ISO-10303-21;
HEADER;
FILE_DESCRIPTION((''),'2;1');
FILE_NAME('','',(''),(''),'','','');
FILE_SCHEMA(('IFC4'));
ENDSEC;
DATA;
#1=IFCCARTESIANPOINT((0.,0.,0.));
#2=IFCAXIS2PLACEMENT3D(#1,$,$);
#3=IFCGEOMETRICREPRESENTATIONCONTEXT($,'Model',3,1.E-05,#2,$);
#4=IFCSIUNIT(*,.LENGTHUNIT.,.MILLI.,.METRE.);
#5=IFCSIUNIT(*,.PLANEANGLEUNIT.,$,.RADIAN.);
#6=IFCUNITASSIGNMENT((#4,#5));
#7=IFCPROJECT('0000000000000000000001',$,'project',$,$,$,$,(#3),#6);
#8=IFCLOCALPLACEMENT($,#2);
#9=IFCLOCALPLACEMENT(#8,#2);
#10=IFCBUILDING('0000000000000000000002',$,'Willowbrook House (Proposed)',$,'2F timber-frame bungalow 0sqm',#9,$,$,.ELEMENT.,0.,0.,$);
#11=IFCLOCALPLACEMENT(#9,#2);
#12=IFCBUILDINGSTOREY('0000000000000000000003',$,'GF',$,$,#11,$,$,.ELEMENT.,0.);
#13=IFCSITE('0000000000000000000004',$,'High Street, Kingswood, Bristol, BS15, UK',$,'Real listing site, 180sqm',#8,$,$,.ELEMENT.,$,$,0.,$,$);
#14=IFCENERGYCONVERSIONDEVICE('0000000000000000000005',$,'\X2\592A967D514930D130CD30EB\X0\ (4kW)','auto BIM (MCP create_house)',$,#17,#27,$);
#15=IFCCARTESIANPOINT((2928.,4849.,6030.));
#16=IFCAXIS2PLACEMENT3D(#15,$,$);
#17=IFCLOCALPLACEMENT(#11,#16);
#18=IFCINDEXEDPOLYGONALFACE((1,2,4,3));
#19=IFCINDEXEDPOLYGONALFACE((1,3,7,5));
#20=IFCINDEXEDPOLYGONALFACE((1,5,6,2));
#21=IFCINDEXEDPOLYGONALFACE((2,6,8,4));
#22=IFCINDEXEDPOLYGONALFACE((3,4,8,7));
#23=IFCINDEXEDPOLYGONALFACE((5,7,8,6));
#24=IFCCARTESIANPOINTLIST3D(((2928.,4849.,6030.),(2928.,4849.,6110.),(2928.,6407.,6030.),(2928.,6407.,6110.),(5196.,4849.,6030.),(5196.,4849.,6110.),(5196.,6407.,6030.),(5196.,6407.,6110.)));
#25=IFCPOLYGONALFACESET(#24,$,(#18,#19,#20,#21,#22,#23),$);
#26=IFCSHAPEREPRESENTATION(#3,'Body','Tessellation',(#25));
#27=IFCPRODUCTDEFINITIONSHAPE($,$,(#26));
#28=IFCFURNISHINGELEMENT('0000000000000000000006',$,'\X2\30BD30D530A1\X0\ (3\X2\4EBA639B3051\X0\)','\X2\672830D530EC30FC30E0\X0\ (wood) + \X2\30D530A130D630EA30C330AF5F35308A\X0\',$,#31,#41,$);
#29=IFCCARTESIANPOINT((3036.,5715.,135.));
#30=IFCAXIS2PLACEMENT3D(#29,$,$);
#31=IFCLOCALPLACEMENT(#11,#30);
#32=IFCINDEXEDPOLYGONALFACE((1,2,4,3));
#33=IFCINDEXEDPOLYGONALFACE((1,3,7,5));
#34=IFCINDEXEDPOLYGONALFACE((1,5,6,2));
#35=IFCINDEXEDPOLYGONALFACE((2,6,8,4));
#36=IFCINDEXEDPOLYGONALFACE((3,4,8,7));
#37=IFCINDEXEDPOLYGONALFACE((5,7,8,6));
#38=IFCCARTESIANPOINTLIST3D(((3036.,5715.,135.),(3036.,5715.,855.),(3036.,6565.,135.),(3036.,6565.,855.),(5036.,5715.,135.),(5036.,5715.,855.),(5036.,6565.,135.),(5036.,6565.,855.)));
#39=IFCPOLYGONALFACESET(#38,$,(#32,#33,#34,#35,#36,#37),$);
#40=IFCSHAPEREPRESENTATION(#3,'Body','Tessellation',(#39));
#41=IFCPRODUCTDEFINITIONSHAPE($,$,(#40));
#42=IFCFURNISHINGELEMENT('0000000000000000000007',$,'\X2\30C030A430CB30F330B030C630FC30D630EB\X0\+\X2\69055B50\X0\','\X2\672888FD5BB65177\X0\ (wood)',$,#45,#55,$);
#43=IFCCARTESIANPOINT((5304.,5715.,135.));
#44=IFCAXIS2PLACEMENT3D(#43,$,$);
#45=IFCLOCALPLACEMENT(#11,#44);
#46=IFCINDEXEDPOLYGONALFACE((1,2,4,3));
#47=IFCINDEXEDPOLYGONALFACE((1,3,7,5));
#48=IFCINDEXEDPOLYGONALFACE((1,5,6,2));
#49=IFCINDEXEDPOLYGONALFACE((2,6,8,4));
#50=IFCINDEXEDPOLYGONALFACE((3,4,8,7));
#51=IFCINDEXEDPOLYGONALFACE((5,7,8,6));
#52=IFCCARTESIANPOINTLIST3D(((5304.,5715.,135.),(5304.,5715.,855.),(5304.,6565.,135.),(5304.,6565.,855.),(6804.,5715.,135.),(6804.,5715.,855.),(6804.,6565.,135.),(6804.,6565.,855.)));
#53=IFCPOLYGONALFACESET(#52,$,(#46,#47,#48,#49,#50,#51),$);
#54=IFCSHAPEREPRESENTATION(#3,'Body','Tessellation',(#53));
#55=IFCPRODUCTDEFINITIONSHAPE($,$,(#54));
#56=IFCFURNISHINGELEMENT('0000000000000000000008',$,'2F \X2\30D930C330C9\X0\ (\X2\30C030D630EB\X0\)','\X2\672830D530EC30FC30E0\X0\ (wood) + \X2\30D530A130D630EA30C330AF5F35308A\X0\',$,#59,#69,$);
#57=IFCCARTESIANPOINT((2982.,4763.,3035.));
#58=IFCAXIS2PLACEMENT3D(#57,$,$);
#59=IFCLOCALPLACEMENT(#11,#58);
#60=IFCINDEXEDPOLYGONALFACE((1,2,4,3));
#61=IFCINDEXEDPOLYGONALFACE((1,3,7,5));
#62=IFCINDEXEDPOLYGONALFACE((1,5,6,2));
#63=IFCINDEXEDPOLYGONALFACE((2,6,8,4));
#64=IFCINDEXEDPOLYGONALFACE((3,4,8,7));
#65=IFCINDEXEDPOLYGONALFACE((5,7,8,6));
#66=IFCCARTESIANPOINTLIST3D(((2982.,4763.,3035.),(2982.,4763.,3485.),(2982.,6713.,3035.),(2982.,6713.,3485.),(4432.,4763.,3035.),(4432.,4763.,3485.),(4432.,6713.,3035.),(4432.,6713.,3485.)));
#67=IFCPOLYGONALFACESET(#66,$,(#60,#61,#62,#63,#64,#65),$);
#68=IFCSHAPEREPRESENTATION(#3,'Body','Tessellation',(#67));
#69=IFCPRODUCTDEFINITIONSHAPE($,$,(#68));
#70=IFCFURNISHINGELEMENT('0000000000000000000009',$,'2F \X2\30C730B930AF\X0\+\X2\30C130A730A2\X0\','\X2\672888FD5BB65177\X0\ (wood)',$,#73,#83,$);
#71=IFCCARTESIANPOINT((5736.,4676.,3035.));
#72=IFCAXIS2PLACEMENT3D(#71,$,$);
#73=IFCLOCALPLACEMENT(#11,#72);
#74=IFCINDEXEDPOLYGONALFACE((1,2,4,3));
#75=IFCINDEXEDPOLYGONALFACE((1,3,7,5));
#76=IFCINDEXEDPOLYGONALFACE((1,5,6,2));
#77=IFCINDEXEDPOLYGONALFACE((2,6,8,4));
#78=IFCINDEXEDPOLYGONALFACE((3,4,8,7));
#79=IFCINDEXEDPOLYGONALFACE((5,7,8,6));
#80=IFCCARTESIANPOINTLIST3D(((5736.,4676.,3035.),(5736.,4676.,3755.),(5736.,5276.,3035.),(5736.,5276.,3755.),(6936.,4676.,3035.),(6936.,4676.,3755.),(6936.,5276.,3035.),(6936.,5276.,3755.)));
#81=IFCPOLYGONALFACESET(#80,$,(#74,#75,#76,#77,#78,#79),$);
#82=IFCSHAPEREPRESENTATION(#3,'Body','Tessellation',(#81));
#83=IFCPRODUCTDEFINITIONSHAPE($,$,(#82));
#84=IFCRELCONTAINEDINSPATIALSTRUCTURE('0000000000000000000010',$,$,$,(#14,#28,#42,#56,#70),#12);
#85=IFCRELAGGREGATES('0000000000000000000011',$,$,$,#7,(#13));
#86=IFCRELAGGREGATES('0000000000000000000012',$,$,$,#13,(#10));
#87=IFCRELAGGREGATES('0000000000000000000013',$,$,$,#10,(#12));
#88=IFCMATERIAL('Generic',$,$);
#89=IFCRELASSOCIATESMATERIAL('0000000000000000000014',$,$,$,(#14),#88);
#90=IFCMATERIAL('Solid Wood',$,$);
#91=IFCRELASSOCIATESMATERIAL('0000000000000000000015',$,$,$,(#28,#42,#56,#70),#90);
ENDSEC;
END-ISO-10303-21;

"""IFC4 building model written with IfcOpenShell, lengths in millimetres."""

from ifc_helpers import new_model, si_unit, frame, frame_2d, origin, place, context, project, spatial, rectangle, extrude, material, element, save


model = new_model("IFC4")

# Units and contexts
model_context = context("Model", 3, precision=1e-05, world=origin())
ifc_project = project(units=[si_unit("LENGTHUNIT", "METRE", prefix="MILLI"), si_unit("PLANEANGLEUNIT", "RADIAN")], contexts=[model_context])

# Site, building, storey
site_placement = place(None, origin())
site = spatial("IfcSite", under=ifc_project, at=site_placement, Name="High Street, Kingswood, Bristol, BS15, UK", ObjectType="Real listing site, 180sqm", CompositionType="ELEMENT", RefElevation=0.0)
building_placement = place(site_placement, origin())
building = spatial("IfcBuilding", under=site, at=building_placement, Name="Willowbrook House (Proposed)", ObjectType="2F timber-frame bungalow 0sqm", CompositionType="ELEMENT", ElevationOfRefHeight=0.0, ElevationOfTerrain=0.0)
storey_placement = place(building_placement, origin())
storey = spatial("IfcBuildingStorey", under=building, at=storey_placement, Name="GF", CompositionType="ELEMENT", Elevation=0.0)

# Shared definitions
ifc_material_1 = material(Name="Solid Wood")

# Shared definitions
ifc_material_2 = material(Name="Generic")

# Energy conversion device
energy_conversion_device_placement = place(storey_placement, frame((2928.0, 4849.0, 6030.0)))
element("IfcEnergyConversionDevice", 1, at=energy_conversion_device_placement, inside=storey, material=ifc_material_2, Name="太陽光パネル (4kW)", Description="auto BIM (MCP create_house)", context=model_context, shape_type="SweptSolid", body=[
    extrude(rectangle(XDim=2268.0, YDim=1558.0, at=frame_2d((1134.0, 779.0))), frame((2928.0, 4849.0, 6030.0)), (0.0, 0.0, 1.0), 80.0),
])

# Furnishing elements
furnishing_1_placement = place(storey_placement, frame((3036.0, 5715.0, 135.0)))
element("IfcFurnishingElement", 2, at=furnishing_1_placement, inside=storey, material=ifc_material_1, Name="ソファ (3人掛け)", Description="木フレーム (wood) + ファブリック張り", context=model_context, shape_type="SweptSolid", body=[
    extrude(rectangle(XDim=2000.0, YDim=850.0, at=frame_2d((1000.0, 425.0))), frame((3036.0, 5715.0, 135.0)), (0.0, 0.0, 1.0), 720.0),
])
furnishing_2_placement = place(storey_placement, frame((5304.0, 5715.0, 135.0)))
element("IfcFurnishingElement", 3, at=furnishing_2_placement, inside=storey, material=ifc_material_1, Name="ダイニングテーブル+椅子", Description="木製家具 (wood)", context=model_context, shape_type="SweptSolid", body=[
    extrude(rectangle(XDim=1500.0, YDim=850.0, at=frame_2d((750.0, 425.0))), frame((5304.0, 5715.0, 135.0)), (0.0, 0.0, 1.0), 720.0),
])
furnishing_3_placement = place(storey_placement, frame((2982.0, 4763.0, 3035.0)))
element("IfcFurnishingElement", 4, at=furnishing_3_placement, inside=storey, material=ifc_material_1, Name="2F ベッド (ダブル)", Description="木フレーム (wood) + ファブリック張り", context=model_context, shape_type="SweptSolid", body=[
    extrude(rectangle(XDim=1450.0, YDim=1950.0, at=frame_2d((725.0, 975.0))), frame((2982.0, 4763.0, 3035.0)), (0.0, 0.0, 1.0), 450.0),
])
furnishing_4_placement = place(storey_placement, frame((5736.0, 4676.0, 3035.0)))
element("IfcFurnishingElement", 5, at=furnishing_4_placement, inside=storey, material=ifc_material_1, Name="2F デスク+チェア", Description="木製家具 (wood)", context=model_context, shape_type="SweptSolid", body=[
    extrude(rectangle(XDim=1200.0, YDim=600.0, at=frame_2d((600.0, 300.0))), frame((5736.0, 4676.0, 3035.0)), (0.0, 0.0, 1.0), 720.0),
])

save(model, "model.ifc")
